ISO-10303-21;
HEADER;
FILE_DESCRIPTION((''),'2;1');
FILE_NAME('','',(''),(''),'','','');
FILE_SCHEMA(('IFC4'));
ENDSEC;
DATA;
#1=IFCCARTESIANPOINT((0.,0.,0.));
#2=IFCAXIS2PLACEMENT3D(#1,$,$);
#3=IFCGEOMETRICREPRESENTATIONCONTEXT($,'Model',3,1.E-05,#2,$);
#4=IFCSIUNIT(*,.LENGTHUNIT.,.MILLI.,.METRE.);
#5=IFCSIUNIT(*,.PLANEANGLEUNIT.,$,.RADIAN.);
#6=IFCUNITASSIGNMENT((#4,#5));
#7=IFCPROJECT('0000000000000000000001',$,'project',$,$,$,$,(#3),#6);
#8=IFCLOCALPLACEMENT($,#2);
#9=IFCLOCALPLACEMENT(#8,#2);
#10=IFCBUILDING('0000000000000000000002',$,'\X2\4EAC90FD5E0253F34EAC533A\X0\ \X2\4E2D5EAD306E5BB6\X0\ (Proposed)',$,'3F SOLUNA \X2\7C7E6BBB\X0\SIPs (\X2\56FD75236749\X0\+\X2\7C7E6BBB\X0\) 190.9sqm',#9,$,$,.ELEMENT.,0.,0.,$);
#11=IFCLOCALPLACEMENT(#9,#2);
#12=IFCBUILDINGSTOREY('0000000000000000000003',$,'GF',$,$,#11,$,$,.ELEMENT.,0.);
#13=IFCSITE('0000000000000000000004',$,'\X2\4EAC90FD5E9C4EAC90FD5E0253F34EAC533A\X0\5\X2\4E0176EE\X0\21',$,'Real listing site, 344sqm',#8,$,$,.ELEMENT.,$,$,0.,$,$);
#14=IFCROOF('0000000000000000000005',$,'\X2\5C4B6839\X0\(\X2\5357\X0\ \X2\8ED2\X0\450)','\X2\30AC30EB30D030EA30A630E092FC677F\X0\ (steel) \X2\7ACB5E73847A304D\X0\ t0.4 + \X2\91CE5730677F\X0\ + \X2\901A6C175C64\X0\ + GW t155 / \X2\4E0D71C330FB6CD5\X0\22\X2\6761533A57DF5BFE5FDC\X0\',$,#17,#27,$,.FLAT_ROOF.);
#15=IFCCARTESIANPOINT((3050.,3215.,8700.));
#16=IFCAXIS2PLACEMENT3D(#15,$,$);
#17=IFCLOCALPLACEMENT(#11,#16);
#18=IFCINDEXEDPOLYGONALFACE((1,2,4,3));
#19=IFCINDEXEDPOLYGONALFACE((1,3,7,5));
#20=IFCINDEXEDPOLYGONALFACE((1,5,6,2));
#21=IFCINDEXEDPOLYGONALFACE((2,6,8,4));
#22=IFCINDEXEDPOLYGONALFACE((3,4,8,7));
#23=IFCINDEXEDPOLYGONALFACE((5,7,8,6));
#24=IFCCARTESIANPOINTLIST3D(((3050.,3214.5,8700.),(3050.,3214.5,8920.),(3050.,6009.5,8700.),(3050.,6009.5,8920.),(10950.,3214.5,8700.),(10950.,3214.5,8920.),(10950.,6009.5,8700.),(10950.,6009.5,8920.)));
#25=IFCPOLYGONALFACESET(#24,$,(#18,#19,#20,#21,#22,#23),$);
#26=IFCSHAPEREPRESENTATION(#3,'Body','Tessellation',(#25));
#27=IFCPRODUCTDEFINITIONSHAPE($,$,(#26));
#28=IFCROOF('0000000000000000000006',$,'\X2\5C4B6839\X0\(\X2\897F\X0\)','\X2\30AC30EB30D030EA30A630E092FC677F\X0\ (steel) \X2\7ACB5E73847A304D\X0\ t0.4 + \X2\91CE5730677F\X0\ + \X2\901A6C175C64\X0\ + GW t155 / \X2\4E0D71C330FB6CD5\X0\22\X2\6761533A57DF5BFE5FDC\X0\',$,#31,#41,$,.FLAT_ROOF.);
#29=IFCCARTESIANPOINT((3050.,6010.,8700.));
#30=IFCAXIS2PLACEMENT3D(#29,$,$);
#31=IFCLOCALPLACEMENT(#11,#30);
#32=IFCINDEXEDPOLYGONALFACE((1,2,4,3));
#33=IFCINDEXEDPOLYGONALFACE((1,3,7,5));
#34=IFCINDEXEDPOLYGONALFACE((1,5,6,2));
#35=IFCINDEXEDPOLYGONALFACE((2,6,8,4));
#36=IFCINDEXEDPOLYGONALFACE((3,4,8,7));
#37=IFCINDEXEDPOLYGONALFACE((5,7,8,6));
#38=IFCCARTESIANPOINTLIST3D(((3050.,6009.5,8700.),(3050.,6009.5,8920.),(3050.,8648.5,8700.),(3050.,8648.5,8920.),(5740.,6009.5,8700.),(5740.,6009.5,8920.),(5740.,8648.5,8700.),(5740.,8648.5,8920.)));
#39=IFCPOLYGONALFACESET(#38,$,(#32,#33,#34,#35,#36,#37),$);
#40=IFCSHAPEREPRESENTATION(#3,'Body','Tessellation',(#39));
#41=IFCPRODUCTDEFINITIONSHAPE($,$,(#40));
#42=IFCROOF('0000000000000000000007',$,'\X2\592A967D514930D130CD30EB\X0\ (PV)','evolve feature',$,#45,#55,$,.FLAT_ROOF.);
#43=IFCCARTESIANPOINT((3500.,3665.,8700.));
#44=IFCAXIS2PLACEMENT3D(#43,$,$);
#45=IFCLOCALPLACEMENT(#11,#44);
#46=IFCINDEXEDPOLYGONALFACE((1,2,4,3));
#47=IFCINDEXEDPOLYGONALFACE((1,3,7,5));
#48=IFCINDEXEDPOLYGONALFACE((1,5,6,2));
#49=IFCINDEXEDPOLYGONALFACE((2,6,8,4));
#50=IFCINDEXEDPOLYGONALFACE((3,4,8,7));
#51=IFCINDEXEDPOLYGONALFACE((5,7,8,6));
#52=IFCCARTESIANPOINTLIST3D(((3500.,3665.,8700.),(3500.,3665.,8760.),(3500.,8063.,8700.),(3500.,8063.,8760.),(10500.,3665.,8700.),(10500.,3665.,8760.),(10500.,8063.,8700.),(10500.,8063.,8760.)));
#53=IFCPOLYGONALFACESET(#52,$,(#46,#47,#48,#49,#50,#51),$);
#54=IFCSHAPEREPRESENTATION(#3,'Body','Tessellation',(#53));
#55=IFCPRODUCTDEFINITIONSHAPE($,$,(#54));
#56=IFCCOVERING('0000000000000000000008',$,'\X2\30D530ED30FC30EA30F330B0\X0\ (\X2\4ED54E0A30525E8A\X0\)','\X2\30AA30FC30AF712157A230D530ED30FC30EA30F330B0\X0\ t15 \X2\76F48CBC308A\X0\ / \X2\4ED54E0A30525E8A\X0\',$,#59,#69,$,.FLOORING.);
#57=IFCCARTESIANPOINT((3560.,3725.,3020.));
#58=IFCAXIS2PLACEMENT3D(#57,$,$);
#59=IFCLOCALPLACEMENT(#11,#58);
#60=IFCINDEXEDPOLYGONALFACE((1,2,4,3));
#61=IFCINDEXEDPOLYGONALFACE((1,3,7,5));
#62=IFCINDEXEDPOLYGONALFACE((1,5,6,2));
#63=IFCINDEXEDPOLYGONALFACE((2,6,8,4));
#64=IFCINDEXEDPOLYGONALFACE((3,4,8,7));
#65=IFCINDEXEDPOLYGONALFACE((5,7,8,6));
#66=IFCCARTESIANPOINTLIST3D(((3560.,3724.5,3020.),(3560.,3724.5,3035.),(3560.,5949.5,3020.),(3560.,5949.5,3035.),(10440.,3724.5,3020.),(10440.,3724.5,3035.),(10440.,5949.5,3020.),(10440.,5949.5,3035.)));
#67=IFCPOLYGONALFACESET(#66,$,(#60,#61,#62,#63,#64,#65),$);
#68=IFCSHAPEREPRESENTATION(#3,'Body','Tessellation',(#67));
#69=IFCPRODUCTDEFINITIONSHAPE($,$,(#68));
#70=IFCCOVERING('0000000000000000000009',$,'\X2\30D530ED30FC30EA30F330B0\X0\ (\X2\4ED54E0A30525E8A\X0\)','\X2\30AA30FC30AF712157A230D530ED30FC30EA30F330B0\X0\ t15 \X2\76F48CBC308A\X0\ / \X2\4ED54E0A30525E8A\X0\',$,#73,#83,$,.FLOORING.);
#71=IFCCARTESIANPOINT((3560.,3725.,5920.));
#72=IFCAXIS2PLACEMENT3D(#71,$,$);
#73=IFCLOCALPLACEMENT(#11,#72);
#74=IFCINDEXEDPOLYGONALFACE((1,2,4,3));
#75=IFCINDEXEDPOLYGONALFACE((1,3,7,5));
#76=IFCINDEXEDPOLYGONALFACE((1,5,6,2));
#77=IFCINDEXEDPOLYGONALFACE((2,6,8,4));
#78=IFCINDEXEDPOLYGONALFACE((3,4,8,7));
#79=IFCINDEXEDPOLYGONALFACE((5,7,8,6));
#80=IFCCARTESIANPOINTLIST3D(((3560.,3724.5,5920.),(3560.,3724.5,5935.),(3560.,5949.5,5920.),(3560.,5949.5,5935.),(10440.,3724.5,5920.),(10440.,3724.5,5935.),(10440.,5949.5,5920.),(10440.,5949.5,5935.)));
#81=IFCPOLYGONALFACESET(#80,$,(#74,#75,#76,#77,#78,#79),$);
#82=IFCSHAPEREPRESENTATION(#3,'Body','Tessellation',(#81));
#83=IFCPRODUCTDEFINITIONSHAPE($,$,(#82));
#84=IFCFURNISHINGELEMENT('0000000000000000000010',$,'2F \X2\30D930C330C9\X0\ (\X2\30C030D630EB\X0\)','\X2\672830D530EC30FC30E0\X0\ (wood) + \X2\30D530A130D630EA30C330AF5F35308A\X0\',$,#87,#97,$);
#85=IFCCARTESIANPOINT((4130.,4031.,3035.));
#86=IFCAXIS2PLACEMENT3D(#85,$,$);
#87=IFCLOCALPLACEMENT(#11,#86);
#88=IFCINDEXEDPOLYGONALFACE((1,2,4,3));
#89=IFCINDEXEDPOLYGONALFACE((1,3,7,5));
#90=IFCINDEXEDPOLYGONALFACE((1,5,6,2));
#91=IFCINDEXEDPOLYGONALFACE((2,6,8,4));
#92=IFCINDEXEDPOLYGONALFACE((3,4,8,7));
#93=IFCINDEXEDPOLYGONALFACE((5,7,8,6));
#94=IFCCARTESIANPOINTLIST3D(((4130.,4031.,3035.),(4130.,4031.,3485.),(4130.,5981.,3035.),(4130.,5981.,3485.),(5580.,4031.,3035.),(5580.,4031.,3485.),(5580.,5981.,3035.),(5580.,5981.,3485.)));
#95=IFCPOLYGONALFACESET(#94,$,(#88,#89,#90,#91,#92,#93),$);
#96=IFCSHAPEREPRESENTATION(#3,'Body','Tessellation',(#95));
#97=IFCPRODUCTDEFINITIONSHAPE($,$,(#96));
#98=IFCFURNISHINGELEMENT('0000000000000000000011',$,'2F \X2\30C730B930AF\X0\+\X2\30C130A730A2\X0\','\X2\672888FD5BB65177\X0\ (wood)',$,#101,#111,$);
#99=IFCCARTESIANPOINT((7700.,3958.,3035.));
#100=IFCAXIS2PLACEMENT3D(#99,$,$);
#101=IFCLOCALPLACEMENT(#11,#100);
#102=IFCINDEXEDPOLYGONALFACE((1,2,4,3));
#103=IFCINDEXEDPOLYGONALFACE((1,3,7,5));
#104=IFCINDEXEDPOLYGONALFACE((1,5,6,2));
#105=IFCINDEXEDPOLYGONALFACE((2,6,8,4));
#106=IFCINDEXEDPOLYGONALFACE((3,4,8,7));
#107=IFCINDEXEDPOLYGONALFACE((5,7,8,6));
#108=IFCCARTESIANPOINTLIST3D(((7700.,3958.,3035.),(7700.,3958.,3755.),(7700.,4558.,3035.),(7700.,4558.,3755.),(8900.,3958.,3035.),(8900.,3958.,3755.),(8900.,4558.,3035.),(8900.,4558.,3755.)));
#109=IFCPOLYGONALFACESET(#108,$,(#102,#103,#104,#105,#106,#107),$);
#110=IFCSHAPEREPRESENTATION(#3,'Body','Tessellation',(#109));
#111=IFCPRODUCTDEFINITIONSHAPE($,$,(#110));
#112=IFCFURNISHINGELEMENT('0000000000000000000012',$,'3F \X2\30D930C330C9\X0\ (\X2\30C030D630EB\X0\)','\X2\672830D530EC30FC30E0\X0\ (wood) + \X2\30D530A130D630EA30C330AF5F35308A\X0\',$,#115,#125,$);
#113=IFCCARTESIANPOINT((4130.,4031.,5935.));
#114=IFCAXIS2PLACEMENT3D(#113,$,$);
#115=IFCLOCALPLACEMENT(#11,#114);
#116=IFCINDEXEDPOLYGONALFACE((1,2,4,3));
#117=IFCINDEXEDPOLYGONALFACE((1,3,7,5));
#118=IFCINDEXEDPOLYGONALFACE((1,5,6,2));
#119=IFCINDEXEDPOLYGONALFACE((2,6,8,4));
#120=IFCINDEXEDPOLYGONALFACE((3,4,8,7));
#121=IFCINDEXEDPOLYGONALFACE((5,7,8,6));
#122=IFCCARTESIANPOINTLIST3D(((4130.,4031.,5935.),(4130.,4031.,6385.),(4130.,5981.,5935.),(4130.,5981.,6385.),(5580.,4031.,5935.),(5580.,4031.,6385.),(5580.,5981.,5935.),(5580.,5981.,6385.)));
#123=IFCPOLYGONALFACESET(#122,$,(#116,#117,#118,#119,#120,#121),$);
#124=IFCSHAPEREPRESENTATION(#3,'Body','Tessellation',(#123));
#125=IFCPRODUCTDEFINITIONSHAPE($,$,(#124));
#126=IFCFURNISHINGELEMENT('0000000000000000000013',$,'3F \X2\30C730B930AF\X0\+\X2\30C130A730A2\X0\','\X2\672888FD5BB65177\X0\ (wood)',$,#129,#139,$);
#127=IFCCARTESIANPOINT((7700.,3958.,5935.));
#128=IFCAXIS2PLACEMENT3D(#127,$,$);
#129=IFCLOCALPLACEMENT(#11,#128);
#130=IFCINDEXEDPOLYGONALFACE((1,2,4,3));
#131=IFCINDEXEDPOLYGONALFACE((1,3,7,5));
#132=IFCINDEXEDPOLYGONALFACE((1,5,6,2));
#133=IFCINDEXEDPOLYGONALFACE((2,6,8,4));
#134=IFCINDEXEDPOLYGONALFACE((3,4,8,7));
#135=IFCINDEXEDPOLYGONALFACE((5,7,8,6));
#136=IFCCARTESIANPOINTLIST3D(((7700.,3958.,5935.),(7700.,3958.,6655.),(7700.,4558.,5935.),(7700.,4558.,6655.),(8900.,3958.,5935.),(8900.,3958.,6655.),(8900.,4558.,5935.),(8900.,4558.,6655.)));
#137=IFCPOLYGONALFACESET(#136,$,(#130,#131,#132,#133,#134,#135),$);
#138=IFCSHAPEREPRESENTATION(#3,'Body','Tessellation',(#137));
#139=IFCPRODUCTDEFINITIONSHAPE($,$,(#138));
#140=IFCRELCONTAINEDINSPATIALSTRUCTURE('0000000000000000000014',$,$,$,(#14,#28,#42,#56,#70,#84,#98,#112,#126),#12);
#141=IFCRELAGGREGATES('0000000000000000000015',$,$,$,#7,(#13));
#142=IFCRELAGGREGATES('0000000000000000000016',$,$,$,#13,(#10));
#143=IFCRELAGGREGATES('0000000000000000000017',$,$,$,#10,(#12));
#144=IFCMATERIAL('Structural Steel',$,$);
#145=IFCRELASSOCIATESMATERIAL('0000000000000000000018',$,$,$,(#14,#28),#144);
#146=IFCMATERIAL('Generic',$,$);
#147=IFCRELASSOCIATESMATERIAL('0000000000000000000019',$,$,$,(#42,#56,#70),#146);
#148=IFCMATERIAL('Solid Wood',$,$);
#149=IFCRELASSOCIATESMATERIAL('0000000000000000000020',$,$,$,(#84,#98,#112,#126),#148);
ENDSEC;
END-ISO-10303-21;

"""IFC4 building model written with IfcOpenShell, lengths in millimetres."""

from ifc_helpers import new_model, si_unit, frame, frame_2d, origin, place, context, project, spatial, rectangle, extrude, material, element, save


model = new_model("IFC4")

# Units and contexts
model_context = context("Model", 3, precision=1e-05, world=origin())
ifc_project = project(units=[si_unit("LENGTHUNIT", "METRE", prefix="MILLI"), si_unit("PLANEANGLEUNIT", "RADIAN")], contexts=[model_context])

# Site, building, storey
site_placement = place(None, origin())
site = spatial("IfcSite", under=ifc_project, at=site_placement, Name="京都府京都市右京区5丁目21", ObjectType="Real listing site, 344sqm", CompositionType="ELEMENT", RefElevation=0.0)
building_placement = place(site_placement, origin())
building = spatial("IfcBuilding", under=site, at=building_placement, Name="京都市右京区 中庭の家 (Proposed)", ObjectType="3F SOLUNA 籾殻SIPs (国産杉+籾殻) 190.9sqm", CompositionType="ELEMENT", ElevationOfRefHeight=0.0, ElevationOfTerrain=0.0)
storey_placement = place(building_placement, origin())
storey = spatial("IfcBuildingStorey", under=building, at=storey_placement, Name="GF", CompositionType="ELEMENT", Elevation=0.0)

# Shared definitions
ifc_material_1 = material(Name="Solid Wood")

# Roofs
ifc_material_2 = material(Name="Structural Steel")
roof_1_placement = place(storey_placement, frame((3050.0, 3215.0, 8700.0)))
element("IfcRoof", 1, at=roof_1_placement, inside=storey, material=ifc_material_2, Name="屋根(南 軒450)", Description="ガルバリウム鋼板 (steel) 立平葺き t0.4 + 野地板 + 通気層 + GW t155 / 不燃・法22条区域対応", PredefinedType="FLAT_ROOF", context=model_context, shape_type="SweptSolid", body=[
    extrude(rectangle(XDim=7900.0, YDim=2795.0, at=frame_2d((3950.0, 1397.0))), frame((3050.0, 3215.0, 8700.0)), (0.0, 0.0, 1.0), 220.0),
])
roof_2_placement = place(storey_placement, frame((3050.0, 6010.0, 8700.0)))
element("IfcRoof", 2, at=roof_2_placement, inside=storey, material=ifc_material_2, Name="屋根(西)", Description="ガルバリウム鋼板 (steel) 立平葺き t0.4 + 野地板 + 通気層 + GW t155 / 不燃・法22条区域対応", PredefinedType="FLAT_ROOF", context=model_context, shape_type="SweptSolid", body=[
    extrude(rectangle(XDim=2690.0, YDim=2639.0, at=frame_2d((1345.0, 1319.0))), frame((3050.0, 6010.0, 8700.0)), (0.0, 0.0, 1.0), 220.0),
])
ifc_material_3 = material(Name="Generic")
roof_3_placement = place(storey_placement, frame((3500.0, 3665.0, 8700.0)))
element("IfcRoof", 3, at=roof_3_placement, inside=storey, material=ifc_material_3, Name="太陽光パネル (PV)", Description="evolve feature", PredefinedType="FLAT_ROOF", context=model_context, shape_type="SweptSolid", body=[
    extrude(rectangle(XDim=7000.0, YDim=4398.0, at=frame_2d((3500.0, 2199.0))), frame((3500.0, 3665.0, 8700.0)), (0.0, 0.0, 1.0), 60.0),
])

# Coverings
covering_1_placement = place(storey_placement, frame((3560.0, 3725.0, 3020.0)))
element("IfcCovering", 4, at=covering_1_placement, inside=storey, material=ifc_material_3, Name="フローリング (仕上げ床)", Description="オーク無垢フローリング t15 直貼り / 仕上げ床", PredefinedType="FLOORING", context=model_context, shape_type="SweptSolid", body=[
    extrude(rectangle(XDim=6880.0, YDim=2225.0, at=frame_2d((3440.0, 1112.0))), frame((3560.0, 3725.0, 3020.0)), (0.0, 0.0, 1.0), 15.0),
])
covering_2_placement = place(storey_placement, frame((3560.0, 3725.0, 5920.0)))
element("IfcCovering", 5, at=covering_2_placement, inside=storey, material=ifc_material_3, Name="フローリング (仕上げ床)", Description="オーク無垢フローリング t15 直貼り / 仕上げ床", PredefinedType="FLOORING", context=model_context, shape_type="SweptSolid", body=[
    extrude(rectangle(XDim=6880.0, YDim=2225.0, at=frame_2d((3440.0, 1112.0))), frame((3560.0, 3725.0, 5920.0)), (0.0, 0.0, 1.0), 15.0),
])

# Furnishing elements
furnishing_1_placement = place(storey_placement, frame((4130.0, 4031.0, 3035.0)))
element("IfcFurnishingElement", 6, at=furnishing_1_placement, inside=storey, material=ifc_material_1, Name="2F ベッド (ダブル)", Description="木フレーム (wood) + ファブリック張り", context=model_context, shape_type="SweptSolid", body=[
    extrude(rectangle(XDim=1450.0, YDim=1950.0, at=frame_2d((725.0, 975.0))), frame((4130.0, 4031.0, 3035.0)), (0.0, 0.0, 1.0), 450.0),
])
furnishing_2_placement = place(storey_placement, frame((7700.0, 3958.0, 3035.0)))
element("IfcFurnishingElement", 7, at=furnishing_2_placement, inside=storey, material=ifc_material_1, Name="2F デスク+チェア", Description="木製家具 (wood)", context=model_context, shape_type="SweptSolid", body=[
    extrude(rectangle(XDim=1200.0, YDim=600.0, at=frame_2d((600.0, 300.0))), frame((7700.0, 3958.0, 3035.0)), (0.0, 0.0, 1.0), 720.0),
])
furnishing_3_placement = place(storey_placement, frame((4130.0, 4031.0, 5935.0)))
element("IfcFurnishingElement", 8, at=furnishing_3_placement, inside=storey, material=ifc_material_1, Name="3F ベッド (ダブル)", Description="木フレーム (wood) + ファブリック張り", context=model_context, shape_type="SweptSolid", body=[
    extrude(rectangle(XDim=1450.0, YDim=1950.0, at=frame_2d((725.0, 975.0))), frame((4130.0, 4031.0, 5935.0)), (0.0, 0.0, 1.0), 450.0),
])
furnishing_4_placement = place(storey_placement, frame((7700.0, 3958.0, 5935.0)))
element("IfcFurnishingElement", 9, at=furnishing_4_placement, inside=storey, material=ifc_material_1, Name="3F デスク+チェア", Description="木製家具 (wood)", context=model_context, shape_type="SweptSolid", body=[
    extrude(rectangle(XDim=1200.0, YDim=600.0, at=frame_2d((600.0, 300.0))), frame((7700.0, 3958.0, 5935.0)), (0.0, 0.0, 1.0), 720.0),
])

save(model, "model.ifc")
